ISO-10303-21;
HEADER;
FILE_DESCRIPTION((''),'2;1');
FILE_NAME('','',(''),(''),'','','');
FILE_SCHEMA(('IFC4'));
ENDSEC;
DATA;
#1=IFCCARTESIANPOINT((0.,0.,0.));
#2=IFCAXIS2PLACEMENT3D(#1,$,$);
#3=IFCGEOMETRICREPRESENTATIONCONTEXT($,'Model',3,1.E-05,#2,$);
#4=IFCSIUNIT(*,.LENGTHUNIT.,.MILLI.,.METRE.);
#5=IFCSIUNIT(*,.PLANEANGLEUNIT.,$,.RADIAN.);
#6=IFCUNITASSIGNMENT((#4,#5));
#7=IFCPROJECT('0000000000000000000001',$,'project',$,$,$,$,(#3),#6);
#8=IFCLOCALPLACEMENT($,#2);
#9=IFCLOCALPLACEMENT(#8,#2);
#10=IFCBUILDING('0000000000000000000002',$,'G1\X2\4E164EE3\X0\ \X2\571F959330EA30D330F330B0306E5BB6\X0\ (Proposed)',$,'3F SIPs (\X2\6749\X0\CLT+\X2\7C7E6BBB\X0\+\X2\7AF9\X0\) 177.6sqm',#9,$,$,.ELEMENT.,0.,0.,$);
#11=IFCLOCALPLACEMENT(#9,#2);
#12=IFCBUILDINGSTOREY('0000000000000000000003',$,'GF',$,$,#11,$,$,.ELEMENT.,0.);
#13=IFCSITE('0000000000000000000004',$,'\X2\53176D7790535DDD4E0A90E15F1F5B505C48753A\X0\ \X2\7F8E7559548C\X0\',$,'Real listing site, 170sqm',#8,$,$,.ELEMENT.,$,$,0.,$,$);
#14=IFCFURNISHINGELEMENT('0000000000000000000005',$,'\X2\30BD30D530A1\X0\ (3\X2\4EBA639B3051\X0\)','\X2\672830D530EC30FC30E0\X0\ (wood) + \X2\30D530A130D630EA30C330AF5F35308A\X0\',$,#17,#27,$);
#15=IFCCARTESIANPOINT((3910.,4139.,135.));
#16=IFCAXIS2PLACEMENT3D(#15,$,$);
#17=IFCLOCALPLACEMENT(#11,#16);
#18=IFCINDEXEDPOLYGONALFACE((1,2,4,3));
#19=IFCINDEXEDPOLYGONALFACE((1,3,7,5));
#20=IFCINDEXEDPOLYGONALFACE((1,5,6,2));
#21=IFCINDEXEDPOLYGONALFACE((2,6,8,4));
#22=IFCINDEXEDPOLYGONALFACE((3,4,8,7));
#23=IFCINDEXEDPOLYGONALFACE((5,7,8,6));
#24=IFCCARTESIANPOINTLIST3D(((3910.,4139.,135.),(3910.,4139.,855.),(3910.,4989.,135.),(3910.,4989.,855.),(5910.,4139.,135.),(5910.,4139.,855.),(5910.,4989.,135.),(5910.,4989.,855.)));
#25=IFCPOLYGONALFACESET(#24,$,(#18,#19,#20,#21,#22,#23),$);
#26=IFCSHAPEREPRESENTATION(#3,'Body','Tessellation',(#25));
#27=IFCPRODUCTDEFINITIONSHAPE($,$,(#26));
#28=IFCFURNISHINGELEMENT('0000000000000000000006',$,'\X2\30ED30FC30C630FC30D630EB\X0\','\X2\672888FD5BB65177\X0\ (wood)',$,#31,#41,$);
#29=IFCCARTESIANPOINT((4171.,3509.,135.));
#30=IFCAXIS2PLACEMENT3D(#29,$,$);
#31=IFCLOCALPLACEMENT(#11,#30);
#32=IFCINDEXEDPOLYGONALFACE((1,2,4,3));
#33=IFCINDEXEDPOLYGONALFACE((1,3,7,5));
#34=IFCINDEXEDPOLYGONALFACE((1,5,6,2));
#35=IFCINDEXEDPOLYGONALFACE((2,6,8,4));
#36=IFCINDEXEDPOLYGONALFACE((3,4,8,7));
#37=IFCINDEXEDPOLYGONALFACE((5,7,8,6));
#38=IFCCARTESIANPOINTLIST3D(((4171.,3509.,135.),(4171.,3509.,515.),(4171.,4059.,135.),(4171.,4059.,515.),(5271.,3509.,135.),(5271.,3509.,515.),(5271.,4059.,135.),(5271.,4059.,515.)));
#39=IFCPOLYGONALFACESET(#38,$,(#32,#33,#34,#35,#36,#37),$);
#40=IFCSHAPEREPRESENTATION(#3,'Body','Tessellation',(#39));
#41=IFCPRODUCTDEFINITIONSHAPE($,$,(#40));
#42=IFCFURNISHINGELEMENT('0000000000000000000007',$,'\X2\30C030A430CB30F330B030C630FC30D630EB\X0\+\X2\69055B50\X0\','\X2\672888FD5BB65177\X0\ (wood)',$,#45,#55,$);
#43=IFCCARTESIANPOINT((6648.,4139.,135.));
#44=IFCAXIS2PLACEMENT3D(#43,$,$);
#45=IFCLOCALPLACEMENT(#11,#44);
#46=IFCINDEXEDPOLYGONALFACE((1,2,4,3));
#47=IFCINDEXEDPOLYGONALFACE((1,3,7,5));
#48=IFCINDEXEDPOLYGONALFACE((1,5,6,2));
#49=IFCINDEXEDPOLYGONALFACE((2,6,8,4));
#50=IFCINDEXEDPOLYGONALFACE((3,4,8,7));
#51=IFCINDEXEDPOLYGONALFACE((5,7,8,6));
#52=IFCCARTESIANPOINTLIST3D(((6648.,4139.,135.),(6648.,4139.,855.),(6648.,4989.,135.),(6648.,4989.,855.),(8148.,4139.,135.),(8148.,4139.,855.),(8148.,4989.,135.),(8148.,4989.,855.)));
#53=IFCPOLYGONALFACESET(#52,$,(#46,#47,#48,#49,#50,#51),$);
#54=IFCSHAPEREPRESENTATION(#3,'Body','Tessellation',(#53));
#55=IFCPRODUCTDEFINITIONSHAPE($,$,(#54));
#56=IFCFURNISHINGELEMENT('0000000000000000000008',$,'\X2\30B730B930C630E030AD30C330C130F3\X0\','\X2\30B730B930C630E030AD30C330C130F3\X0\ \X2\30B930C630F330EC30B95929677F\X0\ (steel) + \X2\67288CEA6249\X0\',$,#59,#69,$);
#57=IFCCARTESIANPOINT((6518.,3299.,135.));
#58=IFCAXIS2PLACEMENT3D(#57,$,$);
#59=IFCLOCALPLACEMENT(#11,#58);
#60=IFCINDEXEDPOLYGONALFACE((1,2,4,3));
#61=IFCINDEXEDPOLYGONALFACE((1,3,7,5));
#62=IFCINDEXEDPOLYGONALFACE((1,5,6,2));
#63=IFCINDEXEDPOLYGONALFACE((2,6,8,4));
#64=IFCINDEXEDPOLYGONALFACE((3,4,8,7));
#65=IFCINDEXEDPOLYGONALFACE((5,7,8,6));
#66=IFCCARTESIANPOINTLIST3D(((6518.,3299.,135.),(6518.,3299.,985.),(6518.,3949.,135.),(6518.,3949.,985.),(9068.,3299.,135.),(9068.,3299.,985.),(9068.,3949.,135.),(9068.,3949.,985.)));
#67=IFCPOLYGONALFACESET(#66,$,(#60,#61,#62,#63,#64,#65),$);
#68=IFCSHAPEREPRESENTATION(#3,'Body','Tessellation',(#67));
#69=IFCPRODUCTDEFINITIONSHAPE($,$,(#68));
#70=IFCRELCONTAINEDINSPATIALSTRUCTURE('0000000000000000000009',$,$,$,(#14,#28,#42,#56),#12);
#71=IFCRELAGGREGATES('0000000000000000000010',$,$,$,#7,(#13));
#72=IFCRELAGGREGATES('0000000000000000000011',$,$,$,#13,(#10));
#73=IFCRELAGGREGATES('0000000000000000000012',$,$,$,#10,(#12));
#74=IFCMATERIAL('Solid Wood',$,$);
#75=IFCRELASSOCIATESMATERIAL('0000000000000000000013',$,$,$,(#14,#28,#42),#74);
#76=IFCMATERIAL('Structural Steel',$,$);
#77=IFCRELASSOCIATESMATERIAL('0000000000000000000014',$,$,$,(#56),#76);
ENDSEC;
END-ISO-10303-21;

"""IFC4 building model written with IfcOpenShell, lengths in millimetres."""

from ifc_helpers import new_model, si_unit, frame, frame_2d, origin, place, context, project, spatial, rectangle, extrude, material, element, save


model = new_model("IFC4")

# Units and contexts
model_context = context("Model", 3, precision=1e-05, world=origin())
ifc_project = project(units=[si_unit("LENGTHUNIT", "METRE", prefix="MILLI"), si_unit("PLANEANGLEUNIT", "RADIAN")], contexts=[model_context])

# Site, building, storey
site_placement = place(None, origin())
site = spatial("IfcSite", under=ifc_project, at=site_placement, Name="北海道川上郡弟子屈町 美留和", ObjectType="Real listing site, 170sqm", CompositionType="ELEMENT", RefElevation=0.0)
building_placement = place(site_placement, origin())
building = spatial("IfcBuilding", under=site, at=building_placement, Name="G1世代 土間リビングの家 (Proposed)", ObjectType="3F SIPs (杉CLT+籾殻+竹) 177.6sqm", CompositionType="ELEMENT", ElevationOfRefHeight=0.0, ElevationOfTerrain=0.0)
storey_placement = place(building_placement, origin())
storey = spatial("IfcBuildingStorey", under=building, at=storey_placement, Name="GF", CompositionType="ELEMENT", Elevation=0.0)

# Shared definitions
ifc_material_1 = material(Name="Solid Wood")

# Furnishing elements
furnishing_1_placement = place(storey_placement, frame((3910.0, 4139.0, 135.0)))
element("IfcFurnishingElement", 1, at=furnishing_1_placement, inside=storey, material=ifc_material_1, Name="ソファ (3人掛け)", Description="木フレーム (wood) + ファブリック張り", context=model_context, shape_type="SweptSolid", body=[
    extrude(rectangle(XDim=2000.0, YDim=850.0, at=frame_2d((1000.0, 425.0))), frame((3910.0, 4139.0, 135.0)), (0.0, 0.0, 1.0), 720.0),
])
furnishing_2_placement = place(storey_placement, frame((4171.0, 3509.0, 135.0)))
element("IfcFurnishingElement", 2, at=furnishing_2_placement, inside=storey, material=ifc_material_1, Name="ローテーブル", Description="木製家具 (wood)", context=model_context, shape_type="SweptSolid", body=[
    extrude(rectangle(XDim=1100.0, YDim=550.0, at=frame_2d((550.0, 275.0))), frame((4171.0, 3509.0, 135.0)), (0.0, 0.0, 1.0), 380.0),
])
furnishing_3_placement = place(storey_placement, frame((6648.0, 4139.0, 135.0)))
element("IfcFurnishingElement", 3, at=furnishing_3_placement, inside=storey, material=ifc_material_1, Name="ダイニングテーブル+椅子", Description="木製家具 (wood)", context=model_context, shape_type="SweptSolid", body=[
    extrude(rectangle(XDim=1500.0, YDim=850.0, at=frame_2d((750.0, 425.0))), frame((6648.0, 4139.0, 135.0)), (0.0, 0.0, 1.0), 720.0),
])
ifc_material_2 = material(Name="Structural Steel")
furnishing_4_placement = place(storey_placement, frame((6518.0, 3299.0, 135.0)))
element("IfcFurnishingElement", 4, at=furnishing_4_placement, inside=storey, material=ifc_material_2, Name="システムキッチン", Description="システムキッチン ステンレス天板 (steel) + 木質扉", context=model_context, shape_type="SweptSolid", body=[
    extrude(rectangle(XDim=2550.0, YDim=650.0, at=frame_2d((1275.0, 325.0))), frame((6518.0, 3299.0, 135.0)), (0.0, 0.0, 1.0), 850.0),
])

save(model, "model.ifc")
